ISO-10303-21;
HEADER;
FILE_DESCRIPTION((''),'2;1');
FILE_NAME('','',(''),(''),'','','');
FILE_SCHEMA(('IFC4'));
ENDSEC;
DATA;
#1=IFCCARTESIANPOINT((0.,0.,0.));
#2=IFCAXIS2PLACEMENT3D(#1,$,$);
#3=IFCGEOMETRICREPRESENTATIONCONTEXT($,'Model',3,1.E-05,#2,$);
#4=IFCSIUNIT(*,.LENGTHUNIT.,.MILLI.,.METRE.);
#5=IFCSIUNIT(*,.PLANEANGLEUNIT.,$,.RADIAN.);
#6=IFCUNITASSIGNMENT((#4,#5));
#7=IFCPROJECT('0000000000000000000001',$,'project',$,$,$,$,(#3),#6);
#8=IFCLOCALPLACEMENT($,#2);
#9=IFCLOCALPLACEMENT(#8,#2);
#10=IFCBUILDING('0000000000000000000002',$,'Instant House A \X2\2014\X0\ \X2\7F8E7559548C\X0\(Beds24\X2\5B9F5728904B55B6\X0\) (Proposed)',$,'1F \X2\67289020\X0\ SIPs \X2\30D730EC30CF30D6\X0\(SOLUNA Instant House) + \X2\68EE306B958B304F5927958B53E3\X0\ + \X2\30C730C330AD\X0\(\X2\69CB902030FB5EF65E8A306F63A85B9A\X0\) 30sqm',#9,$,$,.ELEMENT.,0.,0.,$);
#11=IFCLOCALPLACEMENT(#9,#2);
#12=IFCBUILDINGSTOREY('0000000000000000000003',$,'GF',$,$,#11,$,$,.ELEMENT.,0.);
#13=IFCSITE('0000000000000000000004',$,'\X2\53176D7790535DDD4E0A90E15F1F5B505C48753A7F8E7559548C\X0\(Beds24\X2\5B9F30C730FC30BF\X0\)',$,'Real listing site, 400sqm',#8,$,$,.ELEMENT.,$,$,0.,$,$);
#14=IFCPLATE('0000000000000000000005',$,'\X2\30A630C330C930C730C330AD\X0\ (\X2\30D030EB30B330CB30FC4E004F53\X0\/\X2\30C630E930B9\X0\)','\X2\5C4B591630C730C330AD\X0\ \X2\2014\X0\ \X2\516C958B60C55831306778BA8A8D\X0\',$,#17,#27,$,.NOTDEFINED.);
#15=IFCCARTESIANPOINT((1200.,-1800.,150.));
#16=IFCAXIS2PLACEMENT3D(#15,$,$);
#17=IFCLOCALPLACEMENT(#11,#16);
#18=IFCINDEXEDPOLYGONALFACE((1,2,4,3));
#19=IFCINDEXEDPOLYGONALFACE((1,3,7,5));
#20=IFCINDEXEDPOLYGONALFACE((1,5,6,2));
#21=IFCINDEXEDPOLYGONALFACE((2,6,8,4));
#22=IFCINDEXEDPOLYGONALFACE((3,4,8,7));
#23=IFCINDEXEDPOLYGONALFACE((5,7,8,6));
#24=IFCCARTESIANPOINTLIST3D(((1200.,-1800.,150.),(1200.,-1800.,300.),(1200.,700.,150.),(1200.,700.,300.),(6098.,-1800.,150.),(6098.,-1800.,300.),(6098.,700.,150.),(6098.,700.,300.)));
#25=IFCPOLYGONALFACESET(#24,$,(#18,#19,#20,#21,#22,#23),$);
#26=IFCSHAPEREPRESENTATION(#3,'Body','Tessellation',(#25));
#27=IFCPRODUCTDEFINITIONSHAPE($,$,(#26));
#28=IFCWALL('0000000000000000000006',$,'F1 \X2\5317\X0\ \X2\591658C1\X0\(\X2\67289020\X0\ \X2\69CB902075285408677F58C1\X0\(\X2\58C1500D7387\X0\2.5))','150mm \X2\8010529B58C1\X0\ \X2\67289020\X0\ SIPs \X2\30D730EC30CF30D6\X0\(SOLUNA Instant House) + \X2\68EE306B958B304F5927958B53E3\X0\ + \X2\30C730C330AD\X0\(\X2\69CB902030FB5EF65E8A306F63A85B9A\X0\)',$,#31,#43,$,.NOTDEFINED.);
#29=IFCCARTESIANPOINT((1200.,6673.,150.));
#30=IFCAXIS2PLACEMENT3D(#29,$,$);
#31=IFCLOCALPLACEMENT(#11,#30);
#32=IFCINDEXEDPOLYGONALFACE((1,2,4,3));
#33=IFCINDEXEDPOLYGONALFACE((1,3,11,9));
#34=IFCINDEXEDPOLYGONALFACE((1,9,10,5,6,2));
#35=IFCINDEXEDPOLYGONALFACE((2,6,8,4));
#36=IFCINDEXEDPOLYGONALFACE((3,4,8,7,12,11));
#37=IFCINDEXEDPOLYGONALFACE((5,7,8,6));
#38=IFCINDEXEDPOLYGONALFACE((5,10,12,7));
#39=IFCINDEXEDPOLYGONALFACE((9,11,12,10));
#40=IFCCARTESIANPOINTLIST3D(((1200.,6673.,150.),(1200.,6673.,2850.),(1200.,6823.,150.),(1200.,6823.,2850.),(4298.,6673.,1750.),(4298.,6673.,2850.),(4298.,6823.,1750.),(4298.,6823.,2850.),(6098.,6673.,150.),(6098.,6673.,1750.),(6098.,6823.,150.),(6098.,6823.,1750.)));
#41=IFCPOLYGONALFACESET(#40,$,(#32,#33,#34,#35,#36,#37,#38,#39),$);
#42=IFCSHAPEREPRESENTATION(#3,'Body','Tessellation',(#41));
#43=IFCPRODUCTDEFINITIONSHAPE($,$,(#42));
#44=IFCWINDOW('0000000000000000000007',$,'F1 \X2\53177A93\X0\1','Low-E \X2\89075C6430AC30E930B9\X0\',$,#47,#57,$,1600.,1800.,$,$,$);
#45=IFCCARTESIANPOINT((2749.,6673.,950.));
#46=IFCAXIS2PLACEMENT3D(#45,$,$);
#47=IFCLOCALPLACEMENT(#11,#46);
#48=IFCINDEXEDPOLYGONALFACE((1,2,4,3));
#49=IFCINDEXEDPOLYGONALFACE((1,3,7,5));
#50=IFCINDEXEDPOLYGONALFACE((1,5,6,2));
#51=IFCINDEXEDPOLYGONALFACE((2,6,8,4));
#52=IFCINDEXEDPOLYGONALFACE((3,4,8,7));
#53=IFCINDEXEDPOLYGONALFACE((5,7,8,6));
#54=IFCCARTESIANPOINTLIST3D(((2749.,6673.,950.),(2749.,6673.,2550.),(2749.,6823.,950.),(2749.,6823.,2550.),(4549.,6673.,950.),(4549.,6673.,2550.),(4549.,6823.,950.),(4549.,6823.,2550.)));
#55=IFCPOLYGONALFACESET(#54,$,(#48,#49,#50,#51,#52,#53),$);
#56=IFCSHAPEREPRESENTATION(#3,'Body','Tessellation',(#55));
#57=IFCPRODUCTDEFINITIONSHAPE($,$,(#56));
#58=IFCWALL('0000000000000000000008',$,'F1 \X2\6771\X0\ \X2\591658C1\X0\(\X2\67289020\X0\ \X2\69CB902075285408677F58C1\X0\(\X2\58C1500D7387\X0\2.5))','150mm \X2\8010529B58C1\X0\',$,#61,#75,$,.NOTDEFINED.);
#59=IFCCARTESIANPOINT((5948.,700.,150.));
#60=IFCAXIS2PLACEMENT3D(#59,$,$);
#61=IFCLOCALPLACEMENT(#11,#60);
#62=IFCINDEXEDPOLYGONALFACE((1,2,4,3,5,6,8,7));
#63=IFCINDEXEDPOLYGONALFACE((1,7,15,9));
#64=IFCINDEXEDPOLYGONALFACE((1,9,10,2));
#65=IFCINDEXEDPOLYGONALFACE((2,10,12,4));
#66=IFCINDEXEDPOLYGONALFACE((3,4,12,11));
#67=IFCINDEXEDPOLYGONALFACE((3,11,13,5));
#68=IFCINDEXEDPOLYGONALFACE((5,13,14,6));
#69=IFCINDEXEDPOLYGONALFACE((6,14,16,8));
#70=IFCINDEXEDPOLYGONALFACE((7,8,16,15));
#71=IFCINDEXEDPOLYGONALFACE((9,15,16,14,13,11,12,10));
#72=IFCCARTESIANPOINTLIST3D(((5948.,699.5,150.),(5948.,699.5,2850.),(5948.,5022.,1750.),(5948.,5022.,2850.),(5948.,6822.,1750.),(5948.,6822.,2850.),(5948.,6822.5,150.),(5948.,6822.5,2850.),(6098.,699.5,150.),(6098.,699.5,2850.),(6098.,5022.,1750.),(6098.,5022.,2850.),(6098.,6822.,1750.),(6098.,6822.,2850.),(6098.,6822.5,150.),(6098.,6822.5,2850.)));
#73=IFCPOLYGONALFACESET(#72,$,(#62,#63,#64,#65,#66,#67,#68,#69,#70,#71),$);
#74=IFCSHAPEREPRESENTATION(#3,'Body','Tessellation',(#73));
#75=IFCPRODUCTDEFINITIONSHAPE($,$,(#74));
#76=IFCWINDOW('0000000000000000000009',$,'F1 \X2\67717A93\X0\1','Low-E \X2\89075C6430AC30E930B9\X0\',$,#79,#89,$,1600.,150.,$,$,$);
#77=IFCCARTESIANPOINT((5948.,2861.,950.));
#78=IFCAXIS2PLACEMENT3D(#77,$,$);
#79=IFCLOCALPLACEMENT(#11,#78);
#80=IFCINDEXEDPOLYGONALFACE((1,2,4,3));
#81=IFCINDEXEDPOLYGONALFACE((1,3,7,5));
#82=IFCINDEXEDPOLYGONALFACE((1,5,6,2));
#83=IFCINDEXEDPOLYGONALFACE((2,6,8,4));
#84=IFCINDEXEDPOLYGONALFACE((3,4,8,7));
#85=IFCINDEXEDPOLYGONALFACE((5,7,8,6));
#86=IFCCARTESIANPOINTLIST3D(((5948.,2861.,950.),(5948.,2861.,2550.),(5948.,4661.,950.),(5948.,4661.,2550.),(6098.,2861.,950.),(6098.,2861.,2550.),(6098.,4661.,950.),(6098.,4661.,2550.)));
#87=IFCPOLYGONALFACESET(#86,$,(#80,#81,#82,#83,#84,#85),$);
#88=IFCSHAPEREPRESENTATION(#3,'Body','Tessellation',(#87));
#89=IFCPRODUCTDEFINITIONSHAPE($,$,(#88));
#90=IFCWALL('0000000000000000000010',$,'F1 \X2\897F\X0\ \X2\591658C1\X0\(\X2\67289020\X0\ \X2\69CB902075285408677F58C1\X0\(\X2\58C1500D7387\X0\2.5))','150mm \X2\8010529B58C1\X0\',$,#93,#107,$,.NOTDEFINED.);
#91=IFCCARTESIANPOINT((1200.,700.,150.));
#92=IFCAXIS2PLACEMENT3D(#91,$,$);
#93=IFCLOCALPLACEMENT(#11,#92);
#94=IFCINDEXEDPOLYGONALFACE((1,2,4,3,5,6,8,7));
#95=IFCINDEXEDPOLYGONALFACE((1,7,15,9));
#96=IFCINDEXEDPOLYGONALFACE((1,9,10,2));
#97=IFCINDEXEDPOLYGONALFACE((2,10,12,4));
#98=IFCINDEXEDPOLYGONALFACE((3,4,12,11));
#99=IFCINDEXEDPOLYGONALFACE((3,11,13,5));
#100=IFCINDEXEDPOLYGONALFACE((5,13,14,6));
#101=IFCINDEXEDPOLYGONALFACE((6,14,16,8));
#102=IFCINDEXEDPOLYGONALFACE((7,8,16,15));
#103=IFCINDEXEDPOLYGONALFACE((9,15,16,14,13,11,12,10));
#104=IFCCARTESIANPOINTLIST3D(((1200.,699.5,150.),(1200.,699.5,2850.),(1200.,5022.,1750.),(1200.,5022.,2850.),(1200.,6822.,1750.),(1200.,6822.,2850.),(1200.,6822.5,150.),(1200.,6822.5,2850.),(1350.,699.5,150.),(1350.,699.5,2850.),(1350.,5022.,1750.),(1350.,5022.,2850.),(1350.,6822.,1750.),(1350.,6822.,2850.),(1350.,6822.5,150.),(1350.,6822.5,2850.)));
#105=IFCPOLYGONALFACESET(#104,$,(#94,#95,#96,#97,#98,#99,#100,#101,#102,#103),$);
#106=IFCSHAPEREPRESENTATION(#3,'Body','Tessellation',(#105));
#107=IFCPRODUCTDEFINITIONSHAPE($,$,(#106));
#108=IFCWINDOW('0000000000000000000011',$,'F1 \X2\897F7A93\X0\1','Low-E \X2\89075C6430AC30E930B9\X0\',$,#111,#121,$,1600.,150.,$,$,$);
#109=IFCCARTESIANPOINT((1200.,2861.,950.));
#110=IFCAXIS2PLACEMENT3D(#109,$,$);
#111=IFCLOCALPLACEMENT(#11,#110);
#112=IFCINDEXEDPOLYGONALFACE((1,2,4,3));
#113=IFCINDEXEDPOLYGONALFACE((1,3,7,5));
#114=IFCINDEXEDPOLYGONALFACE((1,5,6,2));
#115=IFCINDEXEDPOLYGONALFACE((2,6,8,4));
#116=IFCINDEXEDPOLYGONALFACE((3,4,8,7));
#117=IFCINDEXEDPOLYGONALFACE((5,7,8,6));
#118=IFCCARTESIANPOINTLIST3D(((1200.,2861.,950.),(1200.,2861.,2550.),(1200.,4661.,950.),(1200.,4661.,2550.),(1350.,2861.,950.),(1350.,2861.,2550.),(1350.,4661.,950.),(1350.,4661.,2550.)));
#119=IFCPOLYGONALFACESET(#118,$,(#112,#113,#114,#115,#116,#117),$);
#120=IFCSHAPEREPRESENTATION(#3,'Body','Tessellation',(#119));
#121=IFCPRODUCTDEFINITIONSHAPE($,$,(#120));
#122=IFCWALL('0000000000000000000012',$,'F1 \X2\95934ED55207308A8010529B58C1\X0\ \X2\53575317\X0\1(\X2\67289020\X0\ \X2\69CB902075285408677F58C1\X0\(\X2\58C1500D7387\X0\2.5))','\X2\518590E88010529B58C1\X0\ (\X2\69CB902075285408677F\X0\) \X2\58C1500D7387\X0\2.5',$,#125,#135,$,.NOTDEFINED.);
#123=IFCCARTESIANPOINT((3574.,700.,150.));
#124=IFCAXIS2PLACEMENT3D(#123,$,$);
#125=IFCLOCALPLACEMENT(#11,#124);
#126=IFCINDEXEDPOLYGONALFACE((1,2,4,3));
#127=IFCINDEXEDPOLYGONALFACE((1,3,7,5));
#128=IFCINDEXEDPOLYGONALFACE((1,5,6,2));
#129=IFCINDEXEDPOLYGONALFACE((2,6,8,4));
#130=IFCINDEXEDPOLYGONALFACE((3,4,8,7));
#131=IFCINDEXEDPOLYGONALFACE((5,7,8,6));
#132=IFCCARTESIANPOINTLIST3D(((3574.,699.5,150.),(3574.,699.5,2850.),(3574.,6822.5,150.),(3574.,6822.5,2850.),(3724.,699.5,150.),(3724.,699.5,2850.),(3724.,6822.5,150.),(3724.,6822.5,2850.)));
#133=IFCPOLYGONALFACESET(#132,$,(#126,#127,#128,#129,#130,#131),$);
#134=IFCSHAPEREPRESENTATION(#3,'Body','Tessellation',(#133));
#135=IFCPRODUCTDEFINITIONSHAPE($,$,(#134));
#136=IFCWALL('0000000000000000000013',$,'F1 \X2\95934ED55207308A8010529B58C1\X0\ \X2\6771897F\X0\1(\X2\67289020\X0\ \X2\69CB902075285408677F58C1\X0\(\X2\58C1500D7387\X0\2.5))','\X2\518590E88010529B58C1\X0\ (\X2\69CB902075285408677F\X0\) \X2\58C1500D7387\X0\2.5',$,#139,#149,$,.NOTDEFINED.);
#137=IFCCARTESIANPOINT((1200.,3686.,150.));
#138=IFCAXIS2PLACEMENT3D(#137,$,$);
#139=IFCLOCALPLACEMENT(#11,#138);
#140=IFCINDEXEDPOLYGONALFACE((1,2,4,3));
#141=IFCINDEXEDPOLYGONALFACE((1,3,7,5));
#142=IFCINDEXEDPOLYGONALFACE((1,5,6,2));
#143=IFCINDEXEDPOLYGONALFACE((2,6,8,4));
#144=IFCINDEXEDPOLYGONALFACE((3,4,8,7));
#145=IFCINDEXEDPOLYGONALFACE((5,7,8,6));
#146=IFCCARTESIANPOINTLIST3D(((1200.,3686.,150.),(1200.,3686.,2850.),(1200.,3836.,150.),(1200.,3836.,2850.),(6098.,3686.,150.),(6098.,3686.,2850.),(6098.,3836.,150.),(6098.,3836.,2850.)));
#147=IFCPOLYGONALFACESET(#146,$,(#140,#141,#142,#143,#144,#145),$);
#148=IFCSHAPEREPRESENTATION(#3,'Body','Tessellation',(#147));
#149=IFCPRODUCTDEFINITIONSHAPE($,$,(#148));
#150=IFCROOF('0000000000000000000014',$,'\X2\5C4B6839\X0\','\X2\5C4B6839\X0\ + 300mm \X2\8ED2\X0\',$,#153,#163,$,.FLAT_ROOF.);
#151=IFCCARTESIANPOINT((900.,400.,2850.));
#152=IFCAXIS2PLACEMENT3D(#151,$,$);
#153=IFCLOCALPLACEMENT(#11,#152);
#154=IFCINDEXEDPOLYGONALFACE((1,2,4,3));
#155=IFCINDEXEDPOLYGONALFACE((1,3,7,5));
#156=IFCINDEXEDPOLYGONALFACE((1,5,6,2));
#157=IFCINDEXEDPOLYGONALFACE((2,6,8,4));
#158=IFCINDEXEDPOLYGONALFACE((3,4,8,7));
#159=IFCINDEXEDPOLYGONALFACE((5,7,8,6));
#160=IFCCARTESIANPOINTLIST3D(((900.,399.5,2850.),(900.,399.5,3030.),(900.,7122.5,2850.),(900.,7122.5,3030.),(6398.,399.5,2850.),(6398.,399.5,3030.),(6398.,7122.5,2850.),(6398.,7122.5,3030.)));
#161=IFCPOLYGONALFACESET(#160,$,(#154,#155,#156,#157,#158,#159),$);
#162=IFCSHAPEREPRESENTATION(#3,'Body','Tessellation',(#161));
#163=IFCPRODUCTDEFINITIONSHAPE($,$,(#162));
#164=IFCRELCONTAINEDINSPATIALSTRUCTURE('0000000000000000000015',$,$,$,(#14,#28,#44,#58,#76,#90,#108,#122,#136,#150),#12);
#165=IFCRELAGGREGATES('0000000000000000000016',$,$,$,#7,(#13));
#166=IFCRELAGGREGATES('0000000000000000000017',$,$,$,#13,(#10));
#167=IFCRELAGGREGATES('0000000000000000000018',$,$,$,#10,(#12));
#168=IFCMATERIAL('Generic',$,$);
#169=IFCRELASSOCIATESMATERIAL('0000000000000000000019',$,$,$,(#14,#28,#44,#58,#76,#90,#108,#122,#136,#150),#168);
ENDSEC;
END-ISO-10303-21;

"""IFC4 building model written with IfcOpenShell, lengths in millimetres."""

from ifc_helpers import new_model, si_unit, frame, frame_2d, origin, place, context, project, spatial, rectangle, extrude, material, element, fill, save


model = new_model("IFC4")

# Units and contexts
model_context = context("Model", 3, precision=1e-05, world=origin())
ifc_project = project(units=[si_unit("LENGTHUNIT", "METRE", prefix="MILLI"), si_unit("PLANEANGLEUNIT", "RADIAN")], contexts=[model_context])

# Site, building, storey
site_placement = place(None, origin())
site = spatial("IfcSite", under=ifc_project, at=site_placement, Name="北海道川上郡弟子屈町美留和(Beds24実データ)", ObjectType="Real listing site, 400sqm", CompositionType="ELEMENT", RefElevation=0.0)
building_placement = place(site_placement, origin())
building = spatial("IfcBuilding", under=site, at=building_placement, Name="Instant House A — 美留和(Beds24実在運営) (Proposed)", ObjectType="1F 木造 SIPs プレハブ(SOLUNA Instant House) + 森に開く大開口 + デッキ(構造・延床は推定) 30sqm", CompositionType="ELEMENT", ElevationOfRefHeight=0.0, ElevationOfTerrain=0.0)
storey_placement = place(building_placement, origin())
storey = spatial("IfcBuildingStorey", under=building, at=storey_placement, Name="GF", CompositionType="ELEMENT", Elevation=0.0)

# Shared definitions
ifc_material_1 = material(Name="Generic")

# Plate
plate_placement = place(storey_placement, frame((1200.0, -1800.0, 150.0)))
element("IfcPlate", 1, at=plate_placement, inside=storey, material=ifc_material_1, Name="ウッドデッキ (バルコニー一体/テラス)", Description="屋外デッキ — 公開情報で確認", PredefinedType="NOTDEFINED", context=model_context, shape_type="SweptSolid", body=[
    extrude(rectangle(XDim=4898.0, YDim=2500.0, at=frame_2d((2449.0, 1250.0))), frame((1200.0, -1800.0, 150.0)), (0.0, 0.0, 1.0), 150.0),
])

# Wall, opening, window
wall_1_placement = place(storey_placement, frame((1200.0, 6673.0, 150.0)))
wall_1 = element("IfcWall", 2, at=wall_1_placement, inside=storey, material=ifc_material_1, Name="F1 北 外壁(木造 構造用合板壁(壁倍率2.5))", Description="150mm 耐力壁 木造 SIPs プレハブ(SOLUNA Instant House) + 森に開く大開口 + デッキ(構造・延床は推定)", PredefinedType="NOTDEFINED", context=model_context, shape_type="SweptSolid", body=[
    extrude(rectangle(XDim=4898.0, YDim=150.0, at=frame_2d((2449.0, 75.0))), frame((1200.0, 6673.0, 150.0)), (0.0, 0.0, 1.0), 2700.0),
])
opening_1_placement = place(storey_placement, frame((2749.0, 6673.0, 950.0)))
opening_1 = element("IfcOpeningElement", 3, at=opening_1_placement, cuts=wall_1, PredefinedType="NOTDEFINED", context=model_context, shape_type="SweptSolid", body=[
    extrude(rectangle(XDim=1800.0, YDim=150.0, at=frame_2d((900.0, 75.0))), frame((2749.0, 6673.0, 950.0)), (0.0, 0.0, 1.0), 1600.0),
])
window_1_placement = place(storey_placement, frame((2749.0, 6673.0, 950.0)))
window_1 = element("IfcWindow", 4, at=window_1_placement, inside=storey, material=ifc_material_1, Name="F1 北窓1", Description="Low-E 複層ガラス", OverallHeight=1600.0, OverallWidth=1800.0, context=model_context, shape_type="SweptSolid", body=[
    extrude(rectangle(XDim=1800.0, YDim=150.0, at=frame_2d((900.0, 75.0))), frame((2749.0, 6673.0, 950.0)), (0.0, 0.0, 1.0), 1600.0),
])
fill(opening_1, window_1)

# Walls, openings, windows
wall_2_placement = place(storey_placement, frame((5948.0, 700.0, 150.0)))
wall_2 = element("IfcWall", 5, at=wall_2_placement, inside=storey, material=ifc_material_1, Name="F1 東 外壁(木造 構造用合板壁(壁倍率2.5))", Description="150mm 耐力壁", PredefinedType="NOTDEFINED", context=model_context, shape_type="SweptSolid", body=[
    extrude(rectangle(XDim=150.0, YDim=6123.0, at=frame_2d((75.0, 3061.0))), frame((5948.0, 700.0, 150.0)), (0.0, 0.0, 1.0), 2700.0),
])
opening_2_placement = place(storey_placement, frame((5948.0, 2861.0, 950.0)))
opening_2 = element("IfcOpeningElement", 6, at=opening_2_placement, cuts=wall_2, PredefinedType="NOTDEFINED", context=model_context, shape_type="SweptSolid", body=[
    extrude(rectangle(XDim=150.0, YDim=1800.0, at=frame_2d((75.0, 900.0))), frame((5948.0, 2861.0, 950.0)), (0.0, 0.0, 1.0), 1600.0),
])
window_2_placement = place(storey_placement, frame((5948.0, 2861.0, 950.0)))
window_2 = element("IfcWindow", 7, at=window_2_placement, inside=storey, material=ifc_material_1, Name="F1 東窓1", Description="Low-E 複層ガラス", OverallHeight=1600.0, OverallWidth=150.0, context=model_context, shape_type="SweptSolid", body=[
    extrude(rectangle(XDim=150.0, YDim=1800.0, at=frame_2d((75.0, 900.0))), frame((5948.0, 2861.0, 950.0)), (0.0, 0.0, 1.0), 1600.0),
])
fill(opening_2, window_2)
wall_3_placement = place(storey_placement, frame((1200.0, 700.0, 150.0)))
wall_3 = element("IfcWall", 8, at=wall_3_placement, inside=storey, material=ifc_material_1, Name="F1 西 外壁(木造 構造用合板壁(壁倍率2.5))", Description="150mm 耐力壁", PredefinedType="NOTDEFINED", context=model_context, shape_type="SweptSolid", body=[
    extrude(rectangle(XDim=150.0, YDim=6123.0, at=frame_2d((75.0, 3061.0))), frame((1200.0, 700.0, 150.0)), (0.0, 0.0, 1.0), 2700.0),
])
opening_3_placement = place(storey_placement, frame((1200.0, 2861.0, 950.0)))
opening_3 = element("IfcOpeningElement", 9, at=opening_3_placement, cuts=wall_3, PredefinedType="NOTDEFINED", context=model_context, shape_type="SweptSolid", body=[
    extrude(rectangle(XDim=150.0, YDim=1800.0, at=frame_2d((75.0, 900.0))), frame((1200.0, 2861.0, 950.0)), (0.0, 0.0, 1.0), 1600.0),
])
window_3_placement = place(storey_placement, frame((1200.0, 2861.0, 950.0)))
window_3 = element("IfcWindow", 10, at=window_3_placement, inside=storey, material=ifc_material_1, Name="F1 西窓1", Description="Low-E 複層ガラス", OverallHeight=1600.0, OverallWidth=150.0, context=model_context, shape_type="SweptSolid", body=[
    extrude(rectangle(XDim=150.0, YDim=1800.0, at=frame_2d((75.0, 900.0))), frame((1200.0, 2861.0, 950.0)), (0.0, 0.0, 1.0), 1600.0),
])
fill(opening_3, window_3)

# Walls
wall_4_placement = place(storey_placement, frame((3574.0, 700.0, 150.0)))
element("IfcWall", 11, at=wall_4_placement, inside=storey, material=ifc_material_1, Name="F1 間仕切り耐力壁 南北1(木造 構造用合板壁(壁倍率2.5))", Description="内部耐力壁 (構造用合板) 壁倍率2.5", PredefinedType="NOTDEFINED", context=model_context, shape_type="SweptSolid", body=[
    extrude(rectangle(XDim=150.0, YDim=6123.0, at=frame_2d((75.0, 3061.0))), frame((3574.0, 700.0, 150.0)), (0.0, 0.0, 1.0), 2700.0),
])
wall_5_placement = place(storey_placement, frame((1200.0, 3686.0, 150.0)))
element("IfcWall", 12, at=wall_5_placement, inside=storey, material=ifc_material_1, Name="F1 間仕切り耐力壁 東西1(木造 構造用合板壁(壁倍率2.5))", Description="内部耐力壁 (構造用合板) 壁倍率2.5", PredefinedType="NOTDEFINED", context=model_context, shape_type="SweptSolid", body=[
    extrude(rectangle(XDim=4898.0, YDim=150.0, at=frame_2d((2449.0, 75.0))), frame((1200.0, 3686.0, 150.0)), (0.0, 0.0, 1.0), 2700.0),
])

# Roof
roof_placement = place(storey_placement, frame((900.0, 400.0, 2850.0)))
element("IfcRoof", 13, at=roof_placement, inside=storey, material=ifc_material_1, Name="屋根", Description="屋根 + 300mm 軒", PredefinedType="FLAT_ROOF", context=model_context, shape_type="SweptSolid", body=[
    extrude(rectangle(XDim=5498.0, YDim=6723.0, at=frame_2d((2749.0, 3361.0))), frame((900.0, 400.0, 2850.0)), (0.0, 0.0, 1.0), 180.0),
])

save(model, "model.ifc")
